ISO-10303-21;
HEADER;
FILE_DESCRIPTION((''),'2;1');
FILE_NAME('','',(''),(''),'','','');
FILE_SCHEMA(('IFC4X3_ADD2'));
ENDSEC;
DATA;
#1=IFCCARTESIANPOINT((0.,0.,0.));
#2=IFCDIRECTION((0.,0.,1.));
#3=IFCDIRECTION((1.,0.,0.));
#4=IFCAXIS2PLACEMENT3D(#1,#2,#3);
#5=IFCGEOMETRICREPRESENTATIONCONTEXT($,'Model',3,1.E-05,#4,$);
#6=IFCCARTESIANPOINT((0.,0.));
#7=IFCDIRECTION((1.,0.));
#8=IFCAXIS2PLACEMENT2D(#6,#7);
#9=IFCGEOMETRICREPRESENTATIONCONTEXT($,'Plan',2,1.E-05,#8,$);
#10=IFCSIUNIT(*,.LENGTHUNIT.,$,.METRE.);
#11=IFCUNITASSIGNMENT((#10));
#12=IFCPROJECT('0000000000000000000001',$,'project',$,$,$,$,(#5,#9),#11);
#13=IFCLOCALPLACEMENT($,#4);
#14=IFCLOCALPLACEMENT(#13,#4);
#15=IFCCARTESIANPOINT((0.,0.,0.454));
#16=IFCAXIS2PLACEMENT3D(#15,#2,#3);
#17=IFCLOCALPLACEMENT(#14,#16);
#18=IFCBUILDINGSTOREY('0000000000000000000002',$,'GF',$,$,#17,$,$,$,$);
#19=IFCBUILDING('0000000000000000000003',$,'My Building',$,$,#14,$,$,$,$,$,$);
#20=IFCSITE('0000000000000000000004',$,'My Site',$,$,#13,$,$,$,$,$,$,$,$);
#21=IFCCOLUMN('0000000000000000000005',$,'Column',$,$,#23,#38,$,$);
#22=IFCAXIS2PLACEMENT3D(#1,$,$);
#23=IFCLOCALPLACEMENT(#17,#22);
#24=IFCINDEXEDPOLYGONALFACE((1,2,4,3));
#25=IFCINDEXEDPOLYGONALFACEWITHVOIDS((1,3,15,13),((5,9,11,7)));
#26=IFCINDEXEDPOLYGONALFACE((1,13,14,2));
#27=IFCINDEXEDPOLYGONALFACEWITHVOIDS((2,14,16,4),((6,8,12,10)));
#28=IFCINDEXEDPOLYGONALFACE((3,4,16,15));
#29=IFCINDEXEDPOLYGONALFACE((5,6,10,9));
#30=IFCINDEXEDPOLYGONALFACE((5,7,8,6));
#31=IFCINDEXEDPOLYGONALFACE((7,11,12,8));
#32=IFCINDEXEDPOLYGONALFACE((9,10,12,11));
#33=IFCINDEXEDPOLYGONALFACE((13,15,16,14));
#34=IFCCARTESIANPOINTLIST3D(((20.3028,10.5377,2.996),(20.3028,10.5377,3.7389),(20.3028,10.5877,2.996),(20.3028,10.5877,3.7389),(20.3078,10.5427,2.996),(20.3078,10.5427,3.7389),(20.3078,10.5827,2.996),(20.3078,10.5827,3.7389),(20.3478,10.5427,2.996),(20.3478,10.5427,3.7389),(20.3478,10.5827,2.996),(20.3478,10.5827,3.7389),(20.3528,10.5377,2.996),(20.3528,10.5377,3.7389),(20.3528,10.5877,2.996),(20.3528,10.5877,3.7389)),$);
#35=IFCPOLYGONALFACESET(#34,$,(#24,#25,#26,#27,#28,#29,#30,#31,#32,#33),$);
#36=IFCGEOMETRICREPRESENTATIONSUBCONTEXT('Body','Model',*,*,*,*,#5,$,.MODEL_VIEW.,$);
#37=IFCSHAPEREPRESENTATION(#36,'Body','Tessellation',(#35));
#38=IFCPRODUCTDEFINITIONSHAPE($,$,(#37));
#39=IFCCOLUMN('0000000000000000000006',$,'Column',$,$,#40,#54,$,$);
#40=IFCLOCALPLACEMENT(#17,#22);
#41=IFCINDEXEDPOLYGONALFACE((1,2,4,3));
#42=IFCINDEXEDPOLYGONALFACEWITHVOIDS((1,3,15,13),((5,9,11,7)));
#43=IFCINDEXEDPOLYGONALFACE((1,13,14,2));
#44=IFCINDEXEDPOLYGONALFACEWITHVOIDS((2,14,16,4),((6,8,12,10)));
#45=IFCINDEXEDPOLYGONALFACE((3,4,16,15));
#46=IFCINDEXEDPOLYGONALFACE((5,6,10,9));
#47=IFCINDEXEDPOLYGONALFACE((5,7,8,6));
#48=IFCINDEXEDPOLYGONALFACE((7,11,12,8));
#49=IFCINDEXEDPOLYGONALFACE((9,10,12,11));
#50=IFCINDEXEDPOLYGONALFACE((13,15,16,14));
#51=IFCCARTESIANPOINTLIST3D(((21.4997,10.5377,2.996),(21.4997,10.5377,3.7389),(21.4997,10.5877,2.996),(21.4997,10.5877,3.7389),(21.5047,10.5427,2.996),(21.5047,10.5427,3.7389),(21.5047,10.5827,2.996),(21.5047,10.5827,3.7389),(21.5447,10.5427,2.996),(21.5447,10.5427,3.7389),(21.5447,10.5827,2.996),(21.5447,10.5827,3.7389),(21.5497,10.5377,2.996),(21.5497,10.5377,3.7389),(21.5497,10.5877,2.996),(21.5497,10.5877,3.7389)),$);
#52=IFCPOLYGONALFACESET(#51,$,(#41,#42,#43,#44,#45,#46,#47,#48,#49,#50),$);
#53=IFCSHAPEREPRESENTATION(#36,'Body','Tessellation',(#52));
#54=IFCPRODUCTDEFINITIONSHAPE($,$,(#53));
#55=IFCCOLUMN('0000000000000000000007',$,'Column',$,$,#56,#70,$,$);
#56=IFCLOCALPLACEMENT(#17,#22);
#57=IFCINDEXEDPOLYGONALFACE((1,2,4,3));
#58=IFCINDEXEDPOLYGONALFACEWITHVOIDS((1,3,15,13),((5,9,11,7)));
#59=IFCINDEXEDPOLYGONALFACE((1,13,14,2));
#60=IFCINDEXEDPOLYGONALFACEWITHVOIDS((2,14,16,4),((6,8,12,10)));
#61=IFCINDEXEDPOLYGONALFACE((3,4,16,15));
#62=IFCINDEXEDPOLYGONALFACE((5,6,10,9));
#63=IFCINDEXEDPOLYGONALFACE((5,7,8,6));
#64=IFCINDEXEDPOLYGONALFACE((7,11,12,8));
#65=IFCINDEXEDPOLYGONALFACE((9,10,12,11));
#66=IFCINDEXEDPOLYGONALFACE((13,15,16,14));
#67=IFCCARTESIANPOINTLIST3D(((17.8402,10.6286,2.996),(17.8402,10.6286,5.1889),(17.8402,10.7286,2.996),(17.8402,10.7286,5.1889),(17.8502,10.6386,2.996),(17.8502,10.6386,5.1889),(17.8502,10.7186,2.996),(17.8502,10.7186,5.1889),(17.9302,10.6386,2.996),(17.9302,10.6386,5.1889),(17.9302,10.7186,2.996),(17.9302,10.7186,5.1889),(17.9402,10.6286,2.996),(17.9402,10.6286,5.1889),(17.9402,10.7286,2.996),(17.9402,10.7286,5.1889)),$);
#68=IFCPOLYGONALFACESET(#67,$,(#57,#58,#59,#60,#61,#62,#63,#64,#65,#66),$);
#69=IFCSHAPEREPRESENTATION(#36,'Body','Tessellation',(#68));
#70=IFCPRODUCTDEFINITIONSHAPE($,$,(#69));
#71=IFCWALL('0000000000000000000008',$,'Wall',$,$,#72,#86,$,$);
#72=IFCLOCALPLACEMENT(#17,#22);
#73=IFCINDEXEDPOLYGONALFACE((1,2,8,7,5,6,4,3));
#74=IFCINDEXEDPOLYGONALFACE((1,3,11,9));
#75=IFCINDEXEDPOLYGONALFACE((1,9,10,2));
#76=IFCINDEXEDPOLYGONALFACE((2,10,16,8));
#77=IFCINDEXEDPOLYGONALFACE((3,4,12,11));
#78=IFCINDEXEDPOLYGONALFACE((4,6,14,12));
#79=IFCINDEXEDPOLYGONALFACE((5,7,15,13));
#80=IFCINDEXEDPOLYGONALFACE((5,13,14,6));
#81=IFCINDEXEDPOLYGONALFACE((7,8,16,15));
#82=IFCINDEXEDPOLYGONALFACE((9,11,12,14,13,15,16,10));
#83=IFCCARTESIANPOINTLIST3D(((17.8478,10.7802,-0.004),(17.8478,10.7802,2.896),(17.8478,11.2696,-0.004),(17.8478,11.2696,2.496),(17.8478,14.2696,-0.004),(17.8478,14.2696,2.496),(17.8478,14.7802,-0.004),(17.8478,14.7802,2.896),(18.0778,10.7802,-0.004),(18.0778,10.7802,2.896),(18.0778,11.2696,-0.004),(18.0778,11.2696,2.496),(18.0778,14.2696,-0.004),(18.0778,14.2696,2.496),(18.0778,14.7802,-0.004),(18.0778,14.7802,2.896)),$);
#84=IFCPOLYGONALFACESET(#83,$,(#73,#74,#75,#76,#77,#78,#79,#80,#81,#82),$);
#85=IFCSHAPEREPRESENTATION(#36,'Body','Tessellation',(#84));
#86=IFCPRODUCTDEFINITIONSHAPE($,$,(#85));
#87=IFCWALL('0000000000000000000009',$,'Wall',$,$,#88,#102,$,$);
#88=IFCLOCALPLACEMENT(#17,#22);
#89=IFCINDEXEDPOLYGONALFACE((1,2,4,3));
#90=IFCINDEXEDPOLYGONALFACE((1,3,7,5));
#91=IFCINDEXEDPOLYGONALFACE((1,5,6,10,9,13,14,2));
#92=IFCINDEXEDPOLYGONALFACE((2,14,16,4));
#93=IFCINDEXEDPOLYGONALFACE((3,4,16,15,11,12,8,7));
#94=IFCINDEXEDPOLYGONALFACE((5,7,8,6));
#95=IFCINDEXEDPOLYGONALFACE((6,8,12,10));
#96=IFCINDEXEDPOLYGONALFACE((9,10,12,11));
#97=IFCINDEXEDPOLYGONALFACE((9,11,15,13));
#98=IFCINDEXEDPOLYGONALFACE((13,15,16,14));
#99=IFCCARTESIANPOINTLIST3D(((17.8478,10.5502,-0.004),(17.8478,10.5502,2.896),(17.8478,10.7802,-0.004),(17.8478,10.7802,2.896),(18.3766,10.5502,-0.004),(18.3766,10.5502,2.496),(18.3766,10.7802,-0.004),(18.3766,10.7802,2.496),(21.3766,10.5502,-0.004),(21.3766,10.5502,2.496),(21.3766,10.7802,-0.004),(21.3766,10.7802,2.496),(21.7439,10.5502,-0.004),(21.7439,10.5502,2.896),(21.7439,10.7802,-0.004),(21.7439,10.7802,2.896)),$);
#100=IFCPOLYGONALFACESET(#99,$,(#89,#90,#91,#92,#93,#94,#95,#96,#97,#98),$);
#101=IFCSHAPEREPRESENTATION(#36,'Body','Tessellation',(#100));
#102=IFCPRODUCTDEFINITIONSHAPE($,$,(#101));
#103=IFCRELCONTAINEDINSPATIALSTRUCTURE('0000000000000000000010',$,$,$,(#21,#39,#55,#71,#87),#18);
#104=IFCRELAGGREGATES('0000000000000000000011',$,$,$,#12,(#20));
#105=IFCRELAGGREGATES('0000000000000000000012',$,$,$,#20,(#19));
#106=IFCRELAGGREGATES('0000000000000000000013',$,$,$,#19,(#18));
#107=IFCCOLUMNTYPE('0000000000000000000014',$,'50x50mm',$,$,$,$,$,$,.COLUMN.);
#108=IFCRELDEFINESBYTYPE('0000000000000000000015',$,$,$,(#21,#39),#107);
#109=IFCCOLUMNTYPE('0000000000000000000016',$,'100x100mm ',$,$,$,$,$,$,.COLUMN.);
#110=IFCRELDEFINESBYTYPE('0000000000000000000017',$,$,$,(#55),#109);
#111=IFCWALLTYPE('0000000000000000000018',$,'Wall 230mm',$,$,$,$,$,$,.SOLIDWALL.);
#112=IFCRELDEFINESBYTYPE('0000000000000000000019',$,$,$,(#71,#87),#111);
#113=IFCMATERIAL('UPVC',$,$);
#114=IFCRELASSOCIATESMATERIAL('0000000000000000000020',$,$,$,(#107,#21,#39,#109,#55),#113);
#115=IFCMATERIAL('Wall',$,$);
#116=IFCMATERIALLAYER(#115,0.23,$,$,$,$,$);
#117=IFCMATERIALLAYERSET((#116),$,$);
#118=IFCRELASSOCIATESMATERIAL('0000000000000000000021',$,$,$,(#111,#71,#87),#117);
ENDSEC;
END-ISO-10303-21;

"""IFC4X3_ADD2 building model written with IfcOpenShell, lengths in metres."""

from ifc_helpers import new_model, si_unit, frame, origin_with_axes, origin_2d_with_axis, place, context, subcontext, project, spatial, line, indexed_curve, hollow_rectangle, outline, extrude, source, transform, mapped, material, layer, layer_set, layer_usage, material_profile, profile_set, profile_usage, type_object, element, save


model = new_model("IFC4X3_ADD2")

# Units and contexts
model_context = context("Model", 3, precision=1e-05, world=origin_with_axes())
plan_context = context("Plan", 2, precision=1e-05, world=origin_2d_with_axis())
body_context = subcontext(model_context, "Body", "Model", "MODEL_VIEW")
ifc_project = project(units=[si_unit("LENGTHUNIT", "METRE")], contexts=[model_context, plan_context])

# Site, building, storey
site_placement = place(None, origin_with_axes())
site = spatial("IfcSite", under=ifc_project, at=site_placement, Name="My Site")
building_placement = place(site_placement, origin_with_axes())
building = spatial("IfcBuilding", under=site, at=building_placement, Name="My Building")
storey_placement = place(building_placement, frame((0.0, 0.0, 0.454), z_axis=(0.0, 0.0, 1.0), x_axis=(1.0, 0.0, 0.0)))
storey = spatial("IfcBuildingStorey", under=building, at=storey_placement, Name="GF")

# Columns
ifc_material_1 = material(Name="UPVC")
ifc_material_profile_1 = material_profile(ifc_material_1, hollow_rectangle(XDim=0.05, YDim=0.05, WallThickness=0.005))
ifc_profile_set_1 = profile_set([ifc_material_profile_1])
column_type_1 = type_object("IfcColumnType", Name="50x50mm", PredefinedType="COLUMN", material=ifc_profile_set_1)
ifc_profile_usage_1 = profile_usage(ifc_profile_set_1)
column_1_placement = place(storey_placement, frame((20.3278, 10.5627, 2.996), z_axis=(0.0, 0.0, 1.0), x_axis=(1.0, 0.0, 0.0)))
element("IfcColumn", 1, at=column_1_placement, inside=storey, type_object=column_type_1, material=ifc_profile_usage_1, Name="Column", context=body_context, shape_type="SweptSolid", body=[
    extrude(hollow_rectangle(XDim=0.05, YDim=0.05, WallThickness=0.005), origin_with_axes(), (0.0, 0.0, 1.0), 0.7429),
])
ifc_profile_usage_2 = profile_usage(ifc_profile_set_1)
column_2_placement = place(storey_placement, frame((21.5247, 10.5627, 2.996), z_axis=(0.0, 0.0, 1.0), x_axis=(1.0, 0.0, 0.0)))
element("IfcColumn", 2, at=column_2_placement, inside=storey, type_object=column_type_1, material=ifc_profile_usage_2, Name="Column", context=body_context, shape_type="SweptSolid", body=[
    extrude(hollow_rectangle(XDim=0.05, YDim=0.05, WallThickness=0.005), origin_with_axes(), (0.0, 0.0, 1.0), 0.7429),
])
ifc_material_profile_2 = material_profile(ifc_material_1, hollow_rectangle(XDim=0.1, YDim=0.1, WallThickness=0.01))
ifc_profile_set_2 = profile_set([ifc_material_profile_2])
ifc_profile_usage_3 = profile_usage(ifc_profile_set_2)
column_type_2 = type_object("IfcColumnType", Name="100x100mm ", PredefinedType="COLUMN", material=ifc_profile_set_2)
column_3_placement = place(storey_placement, frame((17.8902, 10.6786, 2.996), z_axis=(0.0, 0.0, 1.0), x_axis=(0.0, -1.0, 0.0)))
element("IfcColumn", 3, at=column_3_placement, inside=storey, type_object=column_type_2, material=ifc_profile_usage_3, Name="Column", context=body_context, shape_type="SweptSolid", body=[
    extrude(hollow_rectangle(XDim=0.1, YDim=0.1, WallThickness=0.01), origin_with_axes(), (0.0, 0.0, 1.0), 2.1929),
])

# Walls, openings
ifc_material_2 = material(Name="Wall")
ifc_layer = layer(ifc_material_2, 0.23)
ifc_layer_set = layer_set([ifc_layer])
ifc_layer_usage_1 = layer_usage(ifc_layer_set, "AXIS2", "POSITIVE", 0.0)
wall_type = type_object("IfcWallType", Name="Wall 230mm", PredefinedType="SOLIDWALL", material=ifc_layer_set)
wall_1_placement = place(storey_placement, frame((18.0778, 10.7802, -0.004), z_axis=(0.0, 0.0, 1.0), x_axis=(0.000001, 1.0, 0.0)))
wall_1 = element("IfcWall", 4, at=wall_1_placement, inside=storey, type_object=wall_type, material=ifc_layer_usage_1, Name="Wall", context=body_context, shape_type="SweptSolid", body=[
    extrude(outline(indexed_curve([(0.0, 0.0), (0.0, 0.23), (4.0, 0.23), (4.0, 0.0), (0.0, 0.0)], self_intersect=False)), origin_with_axes(), (0.0, 0.0, 1.0), 2.9),
])
shared_shape = source(origin_with_axes(), body_context, "Body", "SweptSolid", [
    extrude(outline(indexed_curve([(0.0, 0.0), (3.0, 0.0), (3.0, 2.5), (0.0, 2.5)], segments=[line(1, 2, 3, 4, 1)])), frame((0.0, -0.6, 0.0), z_axis=(0.0, -1.0, 0.0), x_axis=(1.0, 0.0, 0.0)), (0.0, 0.0, -1.0), 1.2),
])
opening_1_placement = place(wall_1_placement, frame((0.4894, 0.0, 0.0), z_axis=(0.0, 0.0, 1.0), x_axis=(1.0, 0.0, 0.0)))
element("IfcOpeningElement", 5, at=opening_1_placement, cuts=wall_1, PredefinedType="OPENING", context=body_context, shape_type="MappedRepresentation", body=[
    mapped(shared_shape, transform((0.0, 0.0, 0.0), x_axis=(1.0, 0.0, 0.0), y_axis=(0.0, 1.0, 0.0), z_axis=(0.0, 0.0, 1.0), scale=1.0)),
])
ifc_layer_usage_2 = layer_usage(ifc_layer_set, "AXIS2", "POSITIVE", 0.0)
wall_2_placement = place(storey_placement, frame((21.7439, 10.7802, -0.004), z_axis=(0.0, 0.0, 1.0), x_axis=(-1.0, 0.0, 0.0)))
wall_2 = element("IfcWall", 6, at=wall_2_placement, inside=storey, type_object=wall_type, material=ifc_layer_usage_2, Name="Wall", context=body_context, shape_type="SweptSolid", body=[
    extrude(outline(indexed_curve([(0.0, 0.0), (0.0, 0.23), (3.8962, 0.23), (3.8962, 0.0), (0.0, 0.0)], self_intersect=False)), origin_with_axes(), (0.0, 0.0, 1.0), 2.9),
])
opening_2_placement = place(wall_2_placement, frame((0.3674, 0.0, 0.0), z_axis=(0.0, 0.0, 1.0), x_axis=(1.0, 0.0, 0.0)))
element("IfcOpeningElement", 7, at=opening_2_placement, cuts=wall_2, PredefinedType="OPENING", context=body_context, shape_type="MappedRepresentation", body=[
    mapped(shared_shape, transform((0.0, 0.0, 0.0), x_axis=(1.0, 0.0, 0.0), y_axis=(0.0, 1.0, 0.0), z_axis=(0.0, 0.0, 1.0), scale=1.0)),
])

save(model, "model.ifc")
